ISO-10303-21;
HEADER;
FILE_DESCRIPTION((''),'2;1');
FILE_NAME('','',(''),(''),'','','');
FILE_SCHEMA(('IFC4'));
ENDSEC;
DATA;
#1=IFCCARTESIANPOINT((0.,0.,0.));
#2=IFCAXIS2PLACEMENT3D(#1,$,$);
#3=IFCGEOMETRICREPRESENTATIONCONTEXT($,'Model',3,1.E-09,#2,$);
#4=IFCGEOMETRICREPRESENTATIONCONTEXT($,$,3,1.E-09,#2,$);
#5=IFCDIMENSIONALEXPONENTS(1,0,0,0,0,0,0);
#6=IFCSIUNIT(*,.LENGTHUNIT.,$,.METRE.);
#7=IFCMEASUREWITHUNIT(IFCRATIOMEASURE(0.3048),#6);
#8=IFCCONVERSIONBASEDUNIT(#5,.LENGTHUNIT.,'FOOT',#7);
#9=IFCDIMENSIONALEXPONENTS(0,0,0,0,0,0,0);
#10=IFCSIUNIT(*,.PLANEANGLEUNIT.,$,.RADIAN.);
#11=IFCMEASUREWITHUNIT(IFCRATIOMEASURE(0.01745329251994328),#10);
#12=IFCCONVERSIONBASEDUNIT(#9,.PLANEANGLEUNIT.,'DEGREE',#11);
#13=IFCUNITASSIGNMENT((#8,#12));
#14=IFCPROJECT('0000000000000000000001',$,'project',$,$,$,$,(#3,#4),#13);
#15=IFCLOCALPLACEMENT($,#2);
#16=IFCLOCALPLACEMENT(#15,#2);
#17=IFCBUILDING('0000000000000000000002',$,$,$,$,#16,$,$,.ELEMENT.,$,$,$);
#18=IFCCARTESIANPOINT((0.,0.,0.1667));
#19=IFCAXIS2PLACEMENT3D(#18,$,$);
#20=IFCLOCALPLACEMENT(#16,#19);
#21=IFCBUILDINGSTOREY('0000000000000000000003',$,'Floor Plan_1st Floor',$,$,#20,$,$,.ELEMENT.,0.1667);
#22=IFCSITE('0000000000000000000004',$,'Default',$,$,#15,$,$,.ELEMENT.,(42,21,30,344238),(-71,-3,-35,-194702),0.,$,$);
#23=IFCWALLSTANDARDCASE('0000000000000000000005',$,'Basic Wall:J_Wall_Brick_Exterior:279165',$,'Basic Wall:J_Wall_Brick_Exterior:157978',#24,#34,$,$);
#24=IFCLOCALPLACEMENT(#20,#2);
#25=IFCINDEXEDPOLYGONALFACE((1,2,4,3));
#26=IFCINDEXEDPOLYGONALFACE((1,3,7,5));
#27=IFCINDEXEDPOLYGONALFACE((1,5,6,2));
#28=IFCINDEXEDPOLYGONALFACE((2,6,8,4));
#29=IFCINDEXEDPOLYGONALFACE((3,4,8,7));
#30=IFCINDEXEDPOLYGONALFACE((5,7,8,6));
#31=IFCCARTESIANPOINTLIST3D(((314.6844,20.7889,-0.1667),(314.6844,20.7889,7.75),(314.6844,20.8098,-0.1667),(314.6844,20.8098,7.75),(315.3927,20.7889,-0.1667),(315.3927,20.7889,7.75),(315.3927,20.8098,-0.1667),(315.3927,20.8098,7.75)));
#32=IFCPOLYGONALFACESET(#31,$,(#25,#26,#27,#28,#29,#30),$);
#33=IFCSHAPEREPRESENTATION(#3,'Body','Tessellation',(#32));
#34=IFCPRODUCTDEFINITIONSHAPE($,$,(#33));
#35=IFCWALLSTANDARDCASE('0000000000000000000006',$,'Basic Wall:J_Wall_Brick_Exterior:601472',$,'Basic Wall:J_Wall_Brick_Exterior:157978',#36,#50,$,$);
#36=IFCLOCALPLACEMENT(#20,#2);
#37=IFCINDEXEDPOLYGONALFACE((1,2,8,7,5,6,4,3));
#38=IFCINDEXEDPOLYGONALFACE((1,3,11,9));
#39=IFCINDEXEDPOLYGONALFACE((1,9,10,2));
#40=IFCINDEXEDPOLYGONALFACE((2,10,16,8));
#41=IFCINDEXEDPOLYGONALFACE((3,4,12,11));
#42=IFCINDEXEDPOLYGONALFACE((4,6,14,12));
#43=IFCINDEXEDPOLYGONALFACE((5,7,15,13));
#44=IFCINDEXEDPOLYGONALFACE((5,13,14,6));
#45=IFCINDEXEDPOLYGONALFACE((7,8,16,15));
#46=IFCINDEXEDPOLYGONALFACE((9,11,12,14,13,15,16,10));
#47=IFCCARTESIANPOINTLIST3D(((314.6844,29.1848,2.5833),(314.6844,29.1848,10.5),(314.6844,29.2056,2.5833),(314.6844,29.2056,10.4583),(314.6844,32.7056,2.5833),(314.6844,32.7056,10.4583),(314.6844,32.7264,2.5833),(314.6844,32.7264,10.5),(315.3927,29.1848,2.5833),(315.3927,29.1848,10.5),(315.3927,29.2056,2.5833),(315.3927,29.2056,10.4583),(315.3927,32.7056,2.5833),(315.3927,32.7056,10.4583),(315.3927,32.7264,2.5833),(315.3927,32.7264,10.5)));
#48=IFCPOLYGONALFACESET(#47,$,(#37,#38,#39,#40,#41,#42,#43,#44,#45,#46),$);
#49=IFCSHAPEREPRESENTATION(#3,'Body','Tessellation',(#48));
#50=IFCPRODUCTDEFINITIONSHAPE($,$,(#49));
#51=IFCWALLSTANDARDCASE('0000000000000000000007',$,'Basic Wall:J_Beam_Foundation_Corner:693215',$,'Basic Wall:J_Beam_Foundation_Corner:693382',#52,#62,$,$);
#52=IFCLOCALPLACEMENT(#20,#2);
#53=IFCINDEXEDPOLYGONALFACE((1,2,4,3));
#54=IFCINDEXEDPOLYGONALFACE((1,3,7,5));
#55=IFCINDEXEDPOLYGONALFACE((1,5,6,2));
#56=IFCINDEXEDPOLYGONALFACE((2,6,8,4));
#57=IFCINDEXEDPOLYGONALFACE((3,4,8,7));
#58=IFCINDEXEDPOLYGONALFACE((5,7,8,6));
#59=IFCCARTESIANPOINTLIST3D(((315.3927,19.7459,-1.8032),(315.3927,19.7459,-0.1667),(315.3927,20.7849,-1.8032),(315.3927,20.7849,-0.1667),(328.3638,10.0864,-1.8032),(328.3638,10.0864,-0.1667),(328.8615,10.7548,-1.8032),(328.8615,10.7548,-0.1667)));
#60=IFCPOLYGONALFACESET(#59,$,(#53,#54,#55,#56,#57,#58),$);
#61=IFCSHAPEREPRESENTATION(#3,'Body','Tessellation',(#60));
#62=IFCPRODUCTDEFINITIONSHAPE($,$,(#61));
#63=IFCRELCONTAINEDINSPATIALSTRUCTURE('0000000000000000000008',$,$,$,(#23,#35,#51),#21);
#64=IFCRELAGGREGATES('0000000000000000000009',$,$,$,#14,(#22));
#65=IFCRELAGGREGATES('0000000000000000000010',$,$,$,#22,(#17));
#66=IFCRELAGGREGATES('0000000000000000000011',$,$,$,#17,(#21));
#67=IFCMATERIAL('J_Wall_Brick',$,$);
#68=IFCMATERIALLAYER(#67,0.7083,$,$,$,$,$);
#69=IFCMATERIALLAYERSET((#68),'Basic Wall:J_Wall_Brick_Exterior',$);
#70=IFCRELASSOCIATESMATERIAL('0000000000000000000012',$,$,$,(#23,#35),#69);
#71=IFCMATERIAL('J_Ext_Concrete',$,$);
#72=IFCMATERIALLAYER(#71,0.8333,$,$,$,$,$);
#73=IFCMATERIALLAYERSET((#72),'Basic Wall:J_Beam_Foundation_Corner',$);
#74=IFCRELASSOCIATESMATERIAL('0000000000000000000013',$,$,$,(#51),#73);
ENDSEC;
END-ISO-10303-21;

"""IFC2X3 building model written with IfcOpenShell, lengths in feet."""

from ifc_helpers import new_model, entity, si_unit, converted_unit, frame, frame_2d, origin, place, context, project, spatial, polyline, rectangle, outline, extrude, material, layer, layer_set, layer_usage, element, save


model = new_model("IFC2X3")

# Units and contexts
model_context = context("Model", 3, precision=1e-09, world=origin())
context_of_model = context(None, 3, precision=1e-09, world=origin())
ifc_project = project(units=[converted_unit("LENGTHUNIT", "FOOT", entity("IfcRatioMeasure", 0.3048), si_unit("LENGTHUNIT", "METRE"), dimensions=[1, 0, 0, 0, 0, 0, 0]), converted_unit("PLANEANGLEUNIT", "DEGREE", entity("IfcRatioMeasure", 0.01745329251994328), si_unit("PLANEANGLEUNIT", "RADIAN"), dimensions=[0, 0, 0, 0, 0, 0, 0])], contexts=[model_context, context_of_model])

# Site, building, storey
site_placement = place(None, origin())
site = spatial("IfcSite", under=ifc_project, at=site_placement, Name="Default", CompositionType="ELEMENT", RefLatitude=(42, 21, 30, 344238), RefLongitude=(-71, -3, -35, -194702), RefElevation=0.0)
building_placement = place(site_placement, origin())
building = spatial("IfcBuilding", under=site, at=building_placement, CompositionType="ELEMENT")
storey_placement = place(building_placement, frame((0.0, 0.0, 0.1667)))
storey = spatial("IfcBuildingStorey", under=building, at=storey_placement, Name="Floor Plan_1st Floor", CompositionType="ELEMENT", Elevation=0.1667)

# Wall
ifc_material_1 = material(Name="J_Wall_Brick")
ifc_layer_1 = layer(ifc_material_1, 0.7083)
ifc_layer_set_1 = layer_set([ifc_layer_1], Name="Basic Wall:J_Wall_Brick_Exterior")
ifc_layer_usage_1 = layer_usage(ifc_layer_set_1, "AXIS2", "NEGATIVE", 0.3542)
wall_1_placement = place(storey_placement, frame((315.0385, 20.8098, -0.1667), z_axis=(0.0, 0.0, 1.0), x_axis=(0.0, -1.0, 0.0)))
element("IfcWallStandardCase", 1, at=wall_1_placement, inside=storey, material=ifc_layer_usage_1, Name="Basic Wall:J_Wall_Brick_Exterior:279165", ObjectType="Basic Wall:J_Wall_Brick_Exterior:157978", context=model_context, shape_type="SweptSolid", body=[
    extrude(rectangle(XDim=0.0208, YDim=0.7083, at=frame_2d((0.0104, 0.0), x_axis=(-1.0, 0.0))), origin(), (0.0, 0.0, 1.0), 7.9167),
])

# Wall, opening
ifc_layer_usage_2 = layer_usage(ifc_layer_set_1, "AXIS2", "NEGATIVE", 0.3542)
wall_2_placement = place(storey_placement, frame((315.0385, 32.7264, 2.5833), z_axis=(0.0, 0.0, 1.0), x_axis=(0.0, -1.0, 0.0)))
wall_2 = element("IfcWallStandardCase", 2, at=wall_2_placement, inside=storey, material=ifc_layer_usage_2, Name="Basic Wall:J_Wall_Brick_Exterior:601472", ObjectType="Basic Wall:J_Wall_Brick_Exterior:157978", context=model_context, shape_type="SweptSolid", body=[
    extrude(rectangle(XDim=3.5417, YDim=0.7083, at=frame_2d((1.7708, 0.0), x_axis=(-1.0, 0.0))), origin(), (0.0, 0.0, 1.0), 7.9167),
])
opening_placement = place(wall_2_placement, frame((0.0208, -0.3542, 0.0)))
element("IfcOpeningElement", 3, at=opening_placement, cuts=wall_2, ObjectType="Opening", context=model_context, shape_type="SweptSolid", body=[
    extrude(rectangle(XDim=3.5, YDim=7.875, at=frame_2d((3.9375, 1.75), x_axis=(0.0, 1.0))), frame((0.0, 0.0, 0.0), z_axis=(0.0, 1.0, 0.0), x_axis=(0.0, 0.0, 1.0)), (0.0, 0.0, 1.0), 0.7083),
])

# Wall
ifc_material_2 = material(Name="J_Ext_Concrete")
ifc_layer_2 = layer(ifc_material_2, 0.8333)
ifc_layer_set_2 = layer_set([ifc_layer_2], Name="Basic Wall:J_Beam_Foundation_Corner")
ifc_layer_usage_3 = layer_usage(ifc_layer_set_2, "AXIS2", "NEGATIVE", 0.4167)
wall_3_placement = place(storey_placement, frame((315.1438, 20.4508, -1.8032), z_axis=(0.0, 0.0, 1.0), x_axis=(0.802039, -0.597272, 0.0)))
element("IfcWallStandardCase", 4, at=wall_3_placement, inside=storey, material=ifc_layer_usage_3, Name="Basic Wall:J_Beam_Foundation_Corner:693215", ObjectType="Basic Wall:J_Beam_Foundation_Corner:693382", context=model_context, shape_type="SweptSolid", body=[
    extrude(outline(polyline([(16.7932, -0.4167), (16.7932, 0.4167), (0.0, 0.4167), (0.6206, -0.4167), (16.7932, -0.4167)])), origin(), (0.0, 0.0, 1.0), 1.6365),
])

save(model, "model.ifc")
